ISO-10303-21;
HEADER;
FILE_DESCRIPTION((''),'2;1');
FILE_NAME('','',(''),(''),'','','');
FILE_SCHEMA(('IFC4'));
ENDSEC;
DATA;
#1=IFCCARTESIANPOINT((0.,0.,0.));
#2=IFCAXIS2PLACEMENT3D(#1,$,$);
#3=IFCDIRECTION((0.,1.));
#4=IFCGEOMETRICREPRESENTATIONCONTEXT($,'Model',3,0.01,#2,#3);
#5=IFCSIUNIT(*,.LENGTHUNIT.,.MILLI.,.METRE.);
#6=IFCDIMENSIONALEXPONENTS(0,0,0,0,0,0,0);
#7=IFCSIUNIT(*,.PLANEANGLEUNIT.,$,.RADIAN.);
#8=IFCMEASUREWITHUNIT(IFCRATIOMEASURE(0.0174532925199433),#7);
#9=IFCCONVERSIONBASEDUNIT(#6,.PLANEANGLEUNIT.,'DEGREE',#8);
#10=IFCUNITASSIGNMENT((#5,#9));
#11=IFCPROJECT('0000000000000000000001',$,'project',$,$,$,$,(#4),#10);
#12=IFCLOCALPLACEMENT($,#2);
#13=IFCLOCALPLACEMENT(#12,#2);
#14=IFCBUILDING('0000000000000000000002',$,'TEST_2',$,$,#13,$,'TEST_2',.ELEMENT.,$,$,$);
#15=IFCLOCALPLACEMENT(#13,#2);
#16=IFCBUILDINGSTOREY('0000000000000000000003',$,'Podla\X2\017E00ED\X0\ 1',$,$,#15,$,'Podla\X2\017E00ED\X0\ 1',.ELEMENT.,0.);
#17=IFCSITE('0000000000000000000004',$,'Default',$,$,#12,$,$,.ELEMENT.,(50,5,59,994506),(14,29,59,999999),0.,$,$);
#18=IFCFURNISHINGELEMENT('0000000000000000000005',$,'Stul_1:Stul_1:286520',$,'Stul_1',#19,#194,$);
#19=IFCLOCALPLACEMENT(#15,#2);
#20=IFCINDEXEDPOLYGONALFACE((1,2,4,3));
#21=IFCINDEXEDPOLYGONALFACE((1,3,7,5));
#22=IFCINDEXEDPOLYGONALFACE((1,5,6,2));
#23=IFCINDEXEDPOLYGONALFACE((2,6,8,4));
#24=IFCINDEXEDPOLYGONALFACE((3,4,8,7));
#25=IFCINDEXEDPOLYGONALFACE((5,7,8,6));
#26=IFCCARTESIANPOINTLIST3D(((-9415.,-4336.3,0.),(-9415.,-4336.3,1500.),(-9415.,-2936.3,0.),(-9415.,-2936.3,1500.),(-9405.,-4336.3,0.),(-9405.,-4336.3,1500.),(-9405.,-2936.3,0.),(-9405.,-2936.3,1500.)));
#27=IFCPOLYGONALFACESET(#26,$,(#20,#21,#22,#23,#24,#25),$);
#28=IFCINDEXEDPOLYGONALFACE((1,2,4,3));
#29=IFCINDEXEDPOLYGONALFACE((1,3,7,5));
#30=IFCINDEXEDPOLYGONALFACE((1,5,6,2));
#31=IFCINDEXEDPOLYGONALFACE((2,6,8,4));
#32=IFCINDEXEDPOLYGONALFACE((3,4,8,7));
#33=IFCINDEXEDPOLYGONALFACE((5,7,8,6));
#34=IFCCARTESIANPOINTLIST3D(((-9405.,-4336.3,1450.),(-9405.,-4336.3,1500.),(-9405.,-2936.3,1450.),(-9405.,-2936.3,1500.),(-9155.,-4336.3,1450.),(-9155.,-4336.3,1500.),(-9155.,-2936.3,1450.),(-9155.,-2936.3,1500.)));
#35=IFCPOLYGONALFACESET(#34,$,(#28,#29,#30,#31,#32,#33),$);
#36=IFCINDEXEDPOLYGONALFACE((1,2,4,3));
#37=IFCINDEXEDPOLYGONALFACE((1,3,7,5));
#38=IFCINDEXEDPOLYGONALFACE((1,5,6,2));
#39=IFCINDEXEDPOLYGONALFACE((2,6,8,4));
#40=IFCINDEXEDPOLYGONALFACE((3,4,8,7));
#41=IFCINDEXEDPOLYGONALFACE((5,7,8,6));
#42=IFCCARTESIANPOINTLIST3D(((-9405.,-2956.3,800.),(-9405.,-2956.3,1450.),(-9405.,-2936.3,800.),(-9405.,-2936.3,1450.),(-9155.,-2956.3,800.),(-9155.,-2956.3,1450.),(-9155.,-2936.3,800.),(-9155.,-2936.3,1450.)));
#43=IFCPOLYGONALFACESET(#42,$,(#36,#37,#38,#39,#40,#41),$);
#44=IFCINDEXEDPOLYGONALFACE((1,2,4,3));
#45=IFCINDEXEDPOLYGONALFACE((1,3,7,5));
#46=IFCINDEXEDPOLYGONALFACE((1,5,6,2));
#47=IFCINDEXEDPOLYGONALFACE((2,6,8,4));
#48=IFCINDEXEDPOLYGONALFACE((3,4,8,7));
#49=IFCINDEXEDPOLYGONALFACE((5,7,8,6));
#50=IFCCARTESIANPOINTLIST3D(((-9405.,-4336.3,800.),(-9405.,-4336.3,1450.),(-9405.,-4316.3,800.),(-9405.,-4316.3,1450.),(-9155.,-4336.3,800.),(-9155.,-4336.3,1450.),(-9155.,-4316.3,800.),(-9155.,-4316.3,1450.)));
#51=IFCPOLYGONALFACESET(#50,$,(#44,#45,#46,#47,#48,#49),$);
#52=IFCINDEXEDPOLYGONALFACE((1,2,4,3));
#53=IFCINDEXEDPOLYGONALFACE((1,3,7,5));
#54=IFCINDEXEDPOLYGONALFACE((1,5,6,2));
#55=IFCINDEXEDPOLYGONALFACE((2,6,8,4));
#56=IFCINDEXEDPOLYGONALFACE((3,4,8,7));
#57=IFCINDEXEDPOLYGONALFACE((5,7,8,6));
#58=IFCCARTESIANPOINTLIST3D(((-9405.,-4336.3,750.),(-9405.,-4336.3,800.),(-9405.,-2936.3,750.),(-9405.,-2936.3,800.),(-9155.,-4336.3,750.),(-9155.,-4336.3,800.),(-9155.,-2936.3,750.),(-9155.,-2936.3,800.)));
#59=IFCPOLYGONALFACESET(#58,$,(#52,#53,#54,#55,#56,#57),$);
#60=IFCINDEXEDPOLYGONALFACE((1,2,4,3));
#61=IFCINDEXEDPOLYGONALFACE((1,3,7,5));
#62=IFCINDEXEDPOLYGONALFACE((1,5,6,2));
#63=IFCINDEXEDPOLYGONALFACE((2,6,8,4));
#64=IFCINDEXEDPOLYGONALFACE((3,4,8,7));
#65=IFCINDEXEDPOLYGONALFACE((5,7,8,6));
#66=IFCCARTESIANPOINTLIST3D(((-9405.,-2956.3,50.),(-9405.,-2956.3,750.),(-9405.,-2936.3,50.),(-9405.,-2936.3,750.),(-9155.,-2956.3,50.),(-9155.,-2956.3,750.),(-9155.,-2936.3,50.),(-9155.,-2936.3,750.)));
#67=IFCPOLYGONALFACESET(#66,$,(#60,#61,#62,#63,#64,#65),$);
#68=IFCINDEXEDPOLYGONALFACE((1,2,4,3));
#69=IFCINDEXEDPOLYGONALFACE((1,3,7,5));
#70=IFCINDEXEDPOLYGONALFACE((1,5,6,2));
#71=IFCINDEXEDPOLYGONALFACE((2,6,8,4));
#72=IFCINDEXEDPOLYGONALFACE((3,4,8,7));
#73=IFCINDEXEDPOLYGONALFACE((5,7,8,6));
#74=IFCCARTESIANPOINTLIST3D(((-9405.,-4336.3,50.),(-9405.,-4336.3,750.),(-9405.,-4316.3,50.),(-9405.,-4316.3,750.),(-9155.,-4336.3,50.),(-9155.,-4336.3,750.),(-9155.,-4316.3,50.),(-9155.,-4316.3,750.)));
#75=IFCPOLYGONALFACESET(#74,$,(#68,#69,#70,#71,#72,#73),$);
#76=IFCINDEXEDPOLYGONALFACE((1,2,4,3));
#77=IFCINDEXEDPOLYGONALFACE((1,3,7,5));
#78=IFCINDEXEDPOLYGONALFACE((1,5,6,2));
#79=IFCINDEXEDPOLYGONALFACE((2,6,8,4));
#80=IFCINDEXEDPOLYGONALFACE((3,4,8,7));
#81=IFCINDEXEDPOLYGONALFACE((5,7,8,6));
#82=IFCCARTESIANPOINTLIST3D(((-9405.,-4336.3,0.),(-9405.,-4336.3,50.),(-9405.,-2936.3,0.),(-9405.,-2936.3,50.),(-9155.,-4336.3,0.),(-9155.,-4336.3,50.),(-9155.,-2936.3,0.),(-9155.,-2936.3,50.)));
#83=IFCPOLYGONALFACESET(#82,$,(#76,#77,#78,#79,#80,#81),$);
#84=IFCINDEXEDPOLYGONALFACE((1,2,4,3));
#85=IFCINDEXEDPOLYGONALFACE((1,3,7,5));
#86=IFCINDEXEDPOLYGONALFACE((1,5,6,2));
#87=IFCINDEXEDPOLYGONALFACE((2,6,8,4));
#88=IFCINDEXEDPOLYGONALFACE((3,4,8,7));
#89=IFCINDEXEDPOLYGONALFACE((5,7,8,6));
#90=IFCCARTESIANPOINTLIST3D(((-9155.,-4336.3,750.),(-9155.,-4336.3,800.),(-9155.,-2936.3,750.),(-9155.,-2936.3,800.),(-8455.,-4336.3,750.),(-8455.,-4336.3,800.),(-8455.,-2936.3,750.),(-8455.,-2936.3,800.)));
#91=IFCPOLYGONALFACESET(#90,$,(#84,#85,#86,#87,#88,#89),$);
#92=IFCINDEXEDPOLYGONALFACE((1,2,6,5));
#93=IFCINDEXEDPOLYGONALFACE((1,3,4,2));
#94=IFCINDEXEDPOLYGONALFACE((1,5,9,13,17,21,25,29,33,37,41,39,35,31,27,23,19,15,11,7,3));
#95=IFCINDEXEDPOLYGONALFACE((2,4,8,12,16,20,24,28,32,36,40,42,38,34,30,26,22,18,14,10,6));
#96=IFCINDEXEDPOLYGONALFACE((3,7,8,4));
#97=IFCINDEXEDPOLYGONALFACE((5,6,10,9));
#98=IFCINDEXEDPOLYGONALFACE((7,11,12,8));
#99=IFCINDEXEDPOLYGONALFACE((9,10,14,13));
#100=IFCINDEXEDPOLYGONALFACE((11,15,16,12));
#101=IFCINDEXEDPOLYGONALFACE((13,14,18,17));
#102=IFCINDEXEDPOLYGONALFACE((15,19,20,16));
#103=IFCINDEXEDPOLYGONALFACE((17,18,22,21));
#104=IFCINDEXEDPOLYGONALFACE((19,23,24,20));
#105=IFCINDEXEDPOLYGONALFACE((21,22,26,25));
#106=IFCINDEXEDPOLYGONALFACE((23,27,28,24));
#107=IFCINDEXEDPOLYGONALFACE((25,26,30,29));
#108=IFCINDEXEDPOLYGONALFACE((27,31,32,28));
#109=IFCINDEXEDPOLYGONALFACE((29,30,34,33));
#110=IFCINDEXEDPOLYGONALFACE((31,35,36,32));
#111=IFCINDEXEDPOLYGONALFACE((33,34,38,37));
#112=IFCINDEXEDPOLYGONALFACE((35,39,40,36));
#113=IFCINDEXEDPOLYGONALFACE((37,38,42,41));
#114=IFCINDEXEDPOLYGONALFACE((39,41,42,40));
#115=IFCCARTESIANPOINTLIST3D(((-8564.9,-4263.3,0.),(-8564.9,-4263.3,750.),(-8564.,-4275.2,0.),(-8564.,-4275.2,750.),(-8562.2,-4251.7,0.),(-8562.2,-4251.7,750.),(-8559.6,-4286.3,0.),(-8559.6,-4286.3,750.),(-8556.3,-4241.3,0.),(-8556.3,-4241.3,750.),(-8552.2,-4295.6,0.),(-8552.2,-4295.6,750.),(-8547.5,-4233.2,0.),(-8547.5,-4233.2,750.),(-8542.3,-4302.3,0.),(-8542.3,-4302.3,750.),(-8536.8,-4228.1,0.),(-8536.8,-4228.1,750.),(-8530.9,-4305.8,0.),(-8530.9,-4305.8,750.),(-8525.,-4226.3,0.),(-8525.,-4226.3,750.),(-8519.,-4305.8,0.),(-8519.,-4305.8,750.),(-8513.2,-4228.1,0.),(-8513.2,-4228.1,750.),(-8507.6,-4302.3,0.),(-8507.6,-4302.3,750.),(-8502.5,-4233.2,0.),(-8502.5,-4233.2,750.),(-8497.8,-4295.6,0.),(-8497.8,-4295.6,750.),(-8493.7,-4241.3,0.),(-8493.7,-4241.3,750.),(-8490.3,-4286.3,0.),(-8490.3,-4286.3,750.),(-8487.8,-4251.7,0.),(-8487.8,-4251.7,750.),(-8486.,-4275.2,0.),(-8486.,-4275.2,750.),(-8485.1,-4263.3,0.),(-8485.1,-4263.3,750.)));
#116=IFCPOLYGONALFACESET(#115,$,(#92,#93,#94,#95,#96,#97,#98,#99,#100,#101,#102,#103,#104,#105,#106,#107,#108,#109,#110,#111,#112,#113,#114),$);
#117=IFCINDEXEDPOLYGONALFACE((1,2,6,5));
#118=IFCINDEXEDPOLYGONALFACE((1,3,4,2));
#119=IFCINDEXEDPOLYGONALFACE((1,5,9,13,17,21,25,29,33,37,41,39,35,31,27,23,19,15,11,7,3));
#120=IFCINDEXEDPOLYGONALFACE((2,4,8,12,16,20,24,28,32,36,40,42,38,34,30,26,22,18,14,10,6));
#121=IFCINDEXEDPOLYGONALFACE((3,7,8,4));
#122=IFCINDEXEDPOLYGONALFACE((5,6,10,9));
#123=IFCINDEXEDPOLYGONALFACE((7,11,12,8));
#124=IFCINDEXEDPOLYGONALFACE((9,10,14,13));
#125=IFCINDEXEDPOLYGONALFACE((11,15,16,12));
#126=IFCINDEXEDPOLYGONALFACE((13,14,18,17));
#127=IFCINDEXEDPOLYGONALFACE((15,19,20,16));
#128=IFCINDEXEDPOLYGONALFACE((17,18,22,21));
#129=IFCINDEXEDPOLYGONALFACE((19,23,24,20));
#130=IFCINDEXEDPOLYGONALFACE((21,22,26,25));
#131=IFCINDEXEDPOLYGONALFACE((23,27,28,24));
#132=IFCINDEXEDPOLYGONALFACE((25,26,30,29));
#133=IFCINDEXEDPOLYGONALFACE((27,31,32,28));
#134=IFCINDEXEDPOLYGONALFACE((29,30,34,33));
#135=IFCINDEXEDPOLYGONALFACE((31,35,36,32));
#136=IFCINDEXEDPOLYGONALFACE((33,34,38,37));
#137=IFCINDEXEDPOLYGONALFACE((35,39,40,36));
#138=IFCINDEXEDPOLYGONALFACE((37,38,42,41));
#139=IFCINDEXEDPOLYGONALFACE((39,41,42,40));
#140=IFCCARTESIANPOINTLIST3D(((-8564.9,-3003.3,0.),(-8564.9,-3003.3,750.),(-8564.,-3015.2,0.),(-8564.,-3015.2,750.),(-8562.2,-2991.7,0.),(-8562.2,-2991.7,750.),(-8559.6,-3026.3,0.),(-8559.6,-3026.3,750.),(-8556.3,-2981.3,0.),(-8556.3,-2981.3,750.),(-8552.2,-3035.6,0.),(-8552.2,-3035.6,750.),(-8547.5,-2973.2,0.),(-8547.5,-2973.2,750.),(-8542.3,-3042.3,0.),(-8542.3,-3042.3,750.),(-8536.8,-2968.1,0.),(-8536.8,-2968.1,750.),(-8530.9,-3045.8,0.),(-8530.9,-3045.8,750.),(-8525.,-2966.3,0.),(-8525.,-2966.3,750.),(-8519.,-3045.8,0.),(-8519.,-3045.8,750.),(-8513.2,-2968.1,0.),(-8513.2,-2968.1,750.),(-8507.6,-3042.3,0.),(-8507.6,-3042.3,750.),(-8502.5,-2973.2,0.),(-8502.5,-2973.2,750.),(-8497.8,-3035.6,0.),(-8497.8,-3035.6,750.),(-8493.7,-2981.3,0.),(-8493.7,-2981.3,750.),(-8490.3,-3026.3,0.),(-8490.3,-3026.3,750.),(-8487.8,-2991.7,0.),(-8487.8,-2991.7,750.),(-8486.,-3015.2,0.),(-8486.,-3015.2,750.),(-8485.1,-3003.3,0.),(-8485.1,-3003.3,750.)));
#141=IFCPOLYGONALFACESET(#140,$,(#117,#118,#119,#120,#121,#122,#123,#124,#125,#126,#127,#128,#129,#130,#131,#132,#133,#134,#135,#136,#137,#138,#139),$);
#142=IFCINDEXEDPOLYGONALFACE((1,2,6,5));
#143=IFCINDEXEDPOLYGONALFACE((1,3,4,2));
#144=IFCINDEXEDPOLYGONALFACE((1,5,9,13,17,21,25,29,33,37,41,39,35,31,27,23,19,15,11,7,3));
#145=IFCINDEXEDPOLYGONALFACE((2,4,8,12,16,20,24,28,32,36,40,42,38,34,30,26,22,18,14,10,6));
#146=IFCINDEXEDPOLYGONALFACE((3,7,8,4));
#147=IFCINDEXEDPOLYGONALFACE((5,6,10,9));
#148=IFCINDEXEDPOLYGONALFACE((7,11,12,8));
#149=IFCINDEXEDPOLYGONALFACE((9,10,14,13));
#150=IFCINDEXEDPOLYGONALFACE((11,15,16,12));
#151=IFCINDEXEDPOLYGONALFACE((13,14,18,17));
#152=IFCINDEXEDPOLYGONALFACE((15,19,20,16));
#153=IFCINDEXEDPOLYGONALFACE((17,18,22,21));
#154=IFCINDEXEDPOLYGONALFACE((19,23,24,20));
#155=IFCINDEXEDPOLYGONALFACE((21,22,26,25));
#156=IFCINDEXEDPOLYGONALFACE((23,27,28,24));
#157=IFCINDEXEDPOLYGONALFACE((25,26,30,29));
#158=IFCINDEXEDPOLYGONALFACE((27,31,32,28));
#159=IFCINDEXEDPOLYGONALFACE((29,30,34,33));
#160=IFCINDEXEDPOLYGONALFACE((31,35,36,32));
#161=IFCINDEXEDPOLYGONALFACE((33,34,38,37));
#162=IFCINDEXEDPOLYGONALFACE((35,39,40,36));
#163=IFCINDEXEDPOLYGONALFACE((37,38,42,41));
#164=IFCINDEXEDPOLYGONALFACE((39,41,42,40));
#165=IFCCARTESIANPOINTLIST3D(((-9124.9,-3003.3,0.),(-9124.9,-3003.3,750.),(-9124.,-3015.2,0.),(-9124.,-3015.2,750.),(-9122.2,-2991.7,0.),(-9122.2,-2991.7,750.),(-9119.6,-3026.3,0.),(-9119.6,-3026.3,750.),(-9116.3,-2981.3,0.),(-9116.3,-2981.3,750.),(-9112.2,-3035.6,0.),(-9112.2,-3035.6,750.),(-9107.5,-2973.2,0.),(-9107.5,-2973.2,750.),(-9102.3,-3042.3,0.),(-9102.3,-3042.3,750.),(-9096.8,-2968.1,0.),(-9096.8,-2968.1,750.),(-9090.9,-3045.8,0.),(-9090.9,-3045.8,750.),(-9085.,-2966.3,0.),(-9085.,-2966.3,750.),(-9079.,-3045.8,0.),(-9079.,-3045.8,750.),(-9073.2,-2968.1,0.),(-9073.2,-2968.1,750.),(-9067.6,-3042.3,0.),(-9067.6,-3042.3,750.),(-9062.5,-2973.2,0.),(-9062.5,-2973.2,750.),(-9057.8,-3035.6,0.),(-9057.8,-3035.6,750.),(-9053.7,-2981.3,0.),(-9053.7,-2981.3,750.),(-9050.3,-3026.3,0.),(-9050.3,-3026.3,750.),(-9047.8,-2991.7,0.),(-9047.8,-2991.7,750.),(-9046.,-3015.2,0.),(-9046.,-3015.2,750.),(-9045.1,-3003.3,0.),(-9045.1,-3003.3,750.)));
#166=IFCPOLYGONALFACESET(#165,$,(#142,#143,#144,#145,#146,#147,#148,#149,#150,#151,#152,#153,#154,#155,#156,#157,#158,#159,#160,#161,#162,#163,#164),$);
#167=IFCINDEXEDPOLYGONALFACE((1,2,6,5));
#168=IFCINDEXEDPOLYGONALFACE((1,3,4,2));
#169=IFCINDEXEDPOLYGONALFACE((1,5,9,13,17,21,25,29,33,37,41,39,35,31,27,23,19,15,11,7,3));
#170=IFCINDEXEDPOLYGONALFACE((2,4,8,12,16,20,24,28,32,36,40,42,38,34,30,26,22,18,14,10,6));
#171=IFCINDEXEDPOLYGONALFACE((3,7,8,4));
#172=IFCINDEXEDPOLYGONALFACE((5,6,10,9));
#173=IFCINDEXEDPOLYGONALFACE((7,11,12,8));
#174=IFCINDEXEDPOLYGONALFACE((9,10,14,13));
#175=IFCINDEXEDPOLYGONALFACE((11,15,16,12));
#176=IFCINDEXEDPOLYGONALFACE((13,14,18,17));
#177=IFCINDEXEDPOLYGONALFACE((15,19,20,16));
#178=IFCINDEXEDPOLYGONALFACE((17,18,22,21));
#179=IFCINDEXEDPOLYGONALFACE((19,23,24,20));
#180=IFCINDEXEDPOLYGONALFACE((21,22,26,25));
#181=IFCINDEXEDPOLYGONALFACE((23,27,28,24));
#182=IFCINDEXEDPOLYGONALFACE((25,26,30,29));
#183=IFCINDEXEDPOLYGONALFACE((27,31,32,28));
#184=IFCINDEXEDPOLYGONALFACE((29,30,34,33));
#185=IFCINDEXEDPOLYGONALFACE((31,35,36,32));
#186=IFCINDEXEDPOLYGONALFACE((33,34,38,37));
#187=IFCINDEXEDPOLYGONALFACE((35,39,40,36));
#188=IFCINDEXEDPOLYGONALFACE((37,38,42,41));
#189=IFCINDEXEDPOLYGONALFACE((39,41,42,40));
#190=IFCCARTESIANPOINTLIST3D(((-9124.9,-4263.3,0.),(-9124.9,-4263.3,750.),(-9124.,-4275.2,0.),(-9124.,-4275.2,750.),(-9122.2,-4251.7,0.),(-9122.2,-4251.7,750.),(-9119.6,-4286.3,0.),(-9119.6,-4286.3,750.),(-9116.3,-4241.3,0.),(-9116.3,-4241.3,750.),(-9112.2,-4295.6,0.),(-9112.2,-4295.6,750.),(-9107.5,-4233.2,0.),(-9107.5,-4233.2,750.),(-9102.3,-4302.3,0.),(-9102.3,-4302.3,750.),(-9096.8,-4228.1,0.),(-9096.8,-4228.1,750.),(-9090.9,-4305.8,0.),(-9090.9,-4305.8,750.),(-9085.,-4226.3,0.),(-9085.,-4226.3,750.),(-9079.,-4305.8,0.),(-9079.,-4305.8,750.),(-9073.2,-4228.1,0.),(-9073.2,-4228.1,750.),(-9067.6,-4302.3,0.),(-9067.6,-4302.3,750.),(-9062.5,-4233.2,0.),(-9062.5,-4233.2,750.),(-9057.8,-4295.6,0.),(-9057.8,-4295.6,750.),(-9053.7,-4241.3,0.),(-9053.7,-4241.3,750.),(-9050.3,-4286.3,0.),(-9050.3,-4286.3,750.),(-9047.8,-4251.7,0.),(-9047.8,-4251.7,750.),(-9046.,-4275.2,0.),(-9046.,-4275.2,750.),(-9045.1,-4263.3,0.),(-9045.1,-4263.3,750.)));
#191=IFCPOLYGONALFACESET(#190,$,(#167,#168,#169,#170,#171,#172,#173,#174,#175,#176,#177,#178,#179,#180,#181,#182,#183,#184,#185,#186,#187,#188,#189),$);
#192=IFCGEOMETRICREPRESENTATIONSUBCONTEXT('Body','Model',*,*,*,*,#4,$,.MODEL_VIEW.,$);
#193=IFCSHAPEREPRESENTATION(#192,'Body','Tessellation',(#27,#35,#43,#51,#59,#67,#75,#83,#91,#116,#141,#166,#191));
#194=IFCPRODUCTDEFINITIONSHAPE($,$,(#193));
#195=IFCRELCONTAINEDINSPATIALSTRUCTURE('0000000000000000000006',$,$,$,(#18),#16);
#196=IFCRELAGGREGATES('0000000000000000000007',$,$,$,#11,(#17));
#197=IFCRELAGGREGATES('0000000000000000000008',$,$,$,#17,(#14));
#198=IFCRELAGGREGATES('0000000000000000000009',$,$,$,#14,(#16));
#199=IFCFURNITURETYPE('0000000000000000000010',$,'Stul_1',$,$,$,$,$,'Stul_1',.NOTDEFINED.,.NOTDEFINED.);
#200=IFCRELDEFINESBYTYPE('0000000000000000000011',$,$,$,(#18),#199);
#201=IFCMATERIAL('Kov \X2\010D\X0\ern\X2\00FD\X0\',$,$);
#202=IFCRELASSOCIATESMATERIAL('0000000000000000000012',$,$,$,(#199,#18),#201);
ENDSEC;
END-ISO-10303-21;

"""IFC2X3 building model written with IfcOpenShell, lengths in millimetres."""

from ifc_helpers import new_model, entity, si_unit, converted_unit, direction, frame, frame_2d, origin, origin_2d_with_axis, place, context, subcontext, project, spatial, rectangle, circle, extrude, source, transform, mapped, material, type_object, type_shapes, element, save


model = new_model("IFC2X3")

# Units and contexts
model_context = context("Model", 3, precision=0.01, world=origin(), true_north=direction((0.0, 1.0)))
body_context = subcontext(model_context, "Body", "Model", "MODEL_VIEW")
ifc_project = project(units=[si_unit("LENGTHUNIT", "METRE", prefix="MILLI"), converted_unit("PLANEANGLEUNIT", "DEGREE", entity("IfcRatioMeasure", 0.0174532925199433), si_unit("PLANEANGLEUNIT", "RADIAN"), dimensions=[0, 0, 0, 0, 0, 0, 0])], contexts=[model_context])

# Site, building, storey
site_placement = place(None, origin())
site = spatial("IfcSite", under=ifc_project, at=site_placement, Name="Default", CompositionType="ELEMENT", RefLatitude=(50, 5, 59, 994506), RefLongitude=(14, 29, 59, 999999), RefElevation=0.0)
building_placement = place(site_placement, origin())
building = spatial("IfcBuilding", under=site, at=building_placement, Name="TEST_2", LongName="TEST_2", CompositionType="ELEMENT")
storey_placement = place(building_placement, origin())
storey = spatial("IfcBuildingStorey", under=building, at=storey_placement, Name="Podlaží 1", LongName="Podlaží 1", CompositionType="ELEMENT", Elevation=0.0)

# Furnishing element
ifc_material_1 = material(Name="Kov černý")
furniture_type = type_object("IfcFurnitureType", Name="Stul_1", ElementType="Stul_1", material=ifc_material_1)
shared_shape_1 = source(origin(), body_context, "Body", "SweptSolid", [
    extrude(rectangle(XDim=1400.0, YDim=10.0, at=origin_2d_with_axis()), frame((0.0, 605.0, 0.0), z_axis=(0.0, 0.0, 1.0), x_axis=(-1.0, 0.0, 0.0)), (0.0, 0.0, 1.0), 1500.0),
    extrude(rectangle(XDim=1400.0, YDim=250.0, at=frame_2d((0.0, 0.0), x_axis=(1.0, 0.0))), frame((0.0, 475.0, 1450.0), z_axis=(0.0, 0.0, 1.0), x_axis=(-1.0, 0.0, 0.0)), (0.0, 0.0, 1.0), 50.0),
    extrude(rectangle(XDim=20.0, YDim=250.0, at=origin_2d_with_axis()), frame((690.0, 475.0, 800.0), z_axis=(0.0, 0.0, 1.0), x_axis=(-1.0, 0.0, 0.0)), (0.0, 0.0, 1.0), 650.0),
    extrude(rectangle(XDim=20.0, YDim=250.0, at=frame_2d((0.0, 0.0), x_axis=(1.0, 0.0))), frame((-690.0, 475.0, 800.0), z_axis=(0.0, 0.0, 1.0), x_axis=(-1.0, 0.0, 0.0)), (0.0, 0.0, 1.0), 650.0),
    extrude(rectangle(XDim=1400.0, YDim=250.0, at=origin_2d_with_axis()), frame((0.0, 475.0, 750.0), z_axis=(0.0, 0.0, 1.0), x_axis=(-1.0, 0.0, 0.0)), (0.0, 0.0, 1.0), 50.0),
    extrude(rectangle(XDim=20.0, YDim=250.0, at=origin_2d_with_axis()), frame((690.0, 475.0, 50.0), z_axis=(0.0, 0.0, 1.0), x_axis=(-1.0, 0.0, 0.0)), (0.0, 0.0, 1.0), 700.0),
    extrude(rectangle(XDim=20.0, YDim=250.0, at=frame_2d((0.0, 0.0), x_axis=(1.0, 0.0))), frame((-690.0, 475.0, 50.0), z_axis=(0.0, 0.0, 1.0), x_axis=(-1.0, 0.0, 0.0)), (0.0, 0.0, 1.0), 700.0),
    extrude(rectangle(XDim=1400.0, YDim=250.0, at=origin_2d_with_axis()), frame((0.0, 475.0, 0.0), z_axis=(0.0, 0.0, 1.0), x_axis=(-1.0, 0.0, 0.0)), (0.0, 0.0, 1.0), 50.0),
    extrude(rectangle(XDim=1400.0, YDim=700.0, at=origin_2d_with_axis()), frame((0.0, 0.0, 750.0), z_axis=(0.0, 0.0, 1.0), x_axis=(-1.0, 0.0, 0.0)), (0.0, 0.0, 1.0), 50.0),
    extrude(circle(Radius=40.0, at=frame_2d((0.0, 0.0), x_axis=(1.0, 0.0))), frame((-630.0, -280.0, 0.0)), (0.0, 0.0, 1.0), 750.0),
    extrude(circle(Radius=40.0, at=frame_2d((0.0, 0.0), x_axis=(1.0, 0.0))), frame((630.0, -280.0, 0.0)), (0.0, 0.0, 1.0), 750.0),
    extrude(circle(Radius=40.0, at=frame_2d((0.0, 0.0), x_axis=(1.0, 0.0))), frame((630.0, 280.0, 0.0)), (0.0, 0.0, 1.0), 750.0),
    extrude(circle(Radius=40.0, at=frame_2d((0.0, 0.0), x_axis=(1.0, 0.0))), frame((-630.0, 280.0, 0.0)), (0.0, 0.0, 1.0), 750.0),
])
type_shapes(furniture_type, [shared_shape_1])
for number, where, z_axis, x_axis, name in (
    (1, (-8805.0, -3636.3, 0.0), (0.0, 0.0, 1.0), (0.0, 1.0, 0.0), "Stul_1:Stul_1:286520"),
):
    element("IfcFurnishingElement", number, at=place(storey_placement, frame(where, z_axis=z_axis, x_axis=x_axis)), inside=storey, type_object=furniture_type, material=ifc_material_1, Name=name, ObjectType="Stul_1", context=body_context, shape_type="MappedRepresentation", body=[
        mapped(shared_shape_1, transform((0.0, 0.0, 0.0), scale=1.0)),
    ])

save(model, "model.ifc")
